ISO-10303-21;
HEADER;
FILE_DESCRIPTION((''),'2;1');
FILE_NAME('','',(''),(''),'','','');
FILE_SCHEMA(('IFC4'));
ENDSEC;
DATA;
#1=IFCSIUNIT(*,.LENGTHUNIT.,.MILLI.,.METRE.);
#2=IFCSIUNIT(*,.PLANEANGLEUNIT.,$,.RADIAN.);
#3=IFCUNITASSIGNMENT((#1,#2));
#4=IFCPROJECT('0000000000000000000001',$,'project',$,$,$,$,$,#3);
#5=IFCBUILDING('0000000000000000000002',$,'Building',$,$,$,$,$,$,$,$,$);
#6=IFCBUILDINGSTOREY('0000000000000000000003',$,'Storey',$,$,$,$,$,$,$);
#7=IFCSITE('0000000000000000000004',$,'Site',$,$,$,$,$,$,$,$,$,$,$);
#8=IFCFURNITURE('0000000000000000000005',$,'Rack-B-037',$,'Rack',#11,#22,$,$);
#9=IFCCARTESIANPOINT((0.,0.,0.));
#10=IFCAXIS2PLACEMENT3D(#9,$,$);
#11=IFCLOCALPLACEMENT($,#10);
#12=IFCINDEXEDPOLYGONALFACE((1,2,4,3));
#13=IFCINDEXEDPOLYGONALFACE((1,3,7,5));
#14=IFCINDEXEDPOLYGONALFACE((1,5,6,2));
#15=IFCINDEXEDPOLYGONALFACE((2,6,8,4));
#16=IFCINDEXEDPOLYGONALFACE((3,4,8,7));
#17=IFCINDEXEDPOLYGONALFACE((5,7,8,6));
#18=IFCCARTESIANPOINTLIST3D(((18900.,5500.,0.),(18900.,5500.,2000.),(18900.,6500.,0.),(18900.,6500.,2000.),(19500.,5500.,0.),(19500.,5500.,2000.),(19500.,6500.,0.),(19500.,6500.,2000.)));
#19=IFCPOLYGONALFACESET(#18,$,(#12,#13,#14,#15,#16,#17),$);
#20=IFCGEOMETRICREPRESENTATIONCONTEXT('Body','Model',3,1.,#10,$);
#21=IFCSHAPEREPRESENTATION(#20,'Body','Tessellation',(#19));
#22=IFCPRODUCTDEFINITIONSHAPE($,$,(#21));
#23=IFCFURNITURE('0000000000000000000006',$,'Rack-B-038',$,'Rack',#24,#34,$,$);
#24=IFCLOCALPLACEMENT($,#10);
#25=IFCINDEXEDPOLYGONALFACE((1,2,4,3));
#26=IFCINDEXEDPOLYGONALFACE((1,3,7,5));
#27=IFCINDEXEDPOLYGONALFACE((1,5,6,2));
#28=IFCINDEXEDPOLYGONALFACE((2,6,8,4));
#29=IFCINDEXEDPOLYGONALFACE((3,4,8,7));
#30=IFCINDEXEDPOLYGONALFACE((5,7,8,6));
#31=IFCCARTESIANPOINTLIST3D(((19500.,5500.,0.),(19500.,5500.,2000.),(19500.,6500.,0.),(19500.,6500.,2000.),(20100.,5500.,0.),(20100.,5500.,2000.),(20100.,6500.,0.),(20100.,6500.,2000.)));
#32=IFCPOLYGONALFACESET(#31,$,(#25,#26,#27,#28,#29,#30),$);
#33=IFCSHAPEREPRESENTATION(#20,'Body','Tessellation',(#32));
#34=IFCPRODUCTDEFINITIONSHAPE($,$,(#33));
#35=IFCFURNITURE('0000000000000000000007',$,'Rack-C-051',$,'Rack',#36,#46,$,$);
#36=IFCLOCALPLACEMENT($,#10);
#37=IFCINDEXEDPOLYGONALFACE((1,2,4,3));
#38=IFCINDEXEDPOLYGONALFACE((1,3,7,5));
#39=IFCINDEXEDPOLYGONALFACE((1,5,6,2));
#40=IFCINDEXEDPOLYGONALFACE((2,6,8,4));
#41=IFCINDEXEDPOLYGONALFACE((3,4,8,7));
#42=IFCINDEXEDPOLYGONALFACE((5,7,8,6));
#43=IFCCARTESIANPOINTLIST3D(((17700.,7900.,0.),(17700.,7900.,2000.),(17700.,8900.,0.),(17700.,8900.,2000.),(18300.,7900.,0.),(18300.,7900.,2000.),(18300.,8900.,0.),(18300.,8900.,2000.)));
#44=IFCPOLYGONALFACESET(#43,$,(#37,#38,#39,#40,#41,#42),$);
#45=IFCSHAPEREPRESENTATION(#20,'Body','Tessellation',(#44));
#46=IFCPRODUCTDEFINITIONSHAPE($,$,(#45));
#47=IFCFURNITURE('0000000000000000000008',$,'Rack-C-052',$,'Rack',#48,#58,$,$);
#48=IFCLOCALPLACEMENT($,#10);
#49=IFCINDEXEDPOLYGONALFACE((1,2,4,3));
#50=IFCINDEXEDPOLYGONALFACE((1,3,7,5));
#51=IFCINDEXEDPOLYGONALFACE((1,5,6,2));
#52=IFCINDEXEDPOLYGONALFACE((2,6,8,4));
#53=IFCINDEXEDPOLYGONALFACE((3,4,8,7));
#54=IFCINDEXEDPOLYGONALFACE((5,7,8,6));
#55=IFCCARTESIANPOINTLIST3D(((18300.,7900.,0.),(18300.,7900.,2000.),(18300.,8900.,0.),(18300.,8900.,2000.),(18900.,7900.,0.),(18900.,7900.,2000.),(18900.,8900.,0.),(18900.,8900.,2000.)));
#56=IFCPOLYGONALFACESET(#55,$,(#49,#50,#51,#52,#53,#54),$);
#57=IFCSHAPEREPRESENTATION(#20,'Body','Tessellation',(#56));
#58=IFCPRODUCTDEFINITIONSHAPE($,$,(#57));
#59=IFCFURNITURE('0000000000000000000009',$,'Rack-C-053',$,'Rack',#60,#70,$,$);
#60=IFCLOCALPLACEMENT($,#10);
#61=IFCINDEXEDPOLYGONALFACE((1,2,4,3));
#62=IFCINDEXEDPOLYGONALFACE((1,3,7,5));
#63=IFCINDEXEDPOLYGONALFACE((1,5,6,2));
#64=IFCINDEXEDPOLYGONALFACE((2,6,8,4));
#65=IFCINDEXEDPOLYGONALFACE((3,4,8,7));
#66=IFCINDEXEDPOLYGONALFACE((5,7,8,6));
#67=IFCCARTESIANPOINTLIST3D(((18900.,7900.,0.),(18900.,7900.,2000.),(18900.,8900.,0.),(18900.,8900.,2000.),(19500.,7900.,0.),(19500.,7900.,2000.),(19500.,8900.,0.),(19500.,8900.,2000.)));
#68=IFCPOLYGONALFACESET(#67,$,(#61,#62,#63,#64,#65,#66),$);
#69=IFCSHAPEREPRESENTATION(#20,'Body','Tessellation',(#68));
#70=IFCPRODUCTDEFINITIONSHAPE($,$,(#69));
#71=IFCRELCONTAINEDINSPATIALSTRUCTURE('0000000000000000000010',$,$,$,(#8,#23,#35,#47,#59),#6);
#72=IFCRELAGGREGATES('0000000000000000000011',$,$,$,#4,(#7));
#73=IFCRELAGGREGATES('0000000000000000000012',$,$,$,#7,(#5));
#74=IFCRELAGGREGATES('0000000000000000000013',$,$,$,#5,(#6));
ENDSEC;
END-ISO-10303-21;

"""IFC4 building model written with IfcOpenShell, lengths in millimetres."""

from ifc_helpers import new_model, si_unit, frame, origin, place, context, project, spatial, rectangle, extrude, element, save


model = new_model("IFC4")

# Units and contexts
model_context = context("Model", 3, precision=1.0, world=origin(), identifier="Body")
ifc_project = project(units=[si_unit("LENGTHUNIT", "METRE", prefix="MILLI"), si_unit("PLANEANGLEUNIT", "RADIAN")])

# Site, building, storey
site = spatial("IfcSite", under=ifc_project, Name="Site")
building = spatial("IfcBuilding", under=site, Name="Building")
storey = spatial("IfcBuildingStorey", under=building, Name="Storey")

# Furniture
for number, where, z_axis, x_axis, name in (
    (1, (19200.0, 6000.0, 0.0), (0.0, 0.0, 1.0), (1.0, 0.0, 0.0), "Rack-B-037"),
    (2, (19800.0, 6000.0, 0.0), (0.0, 0.0, 1.0), (1.0, 0.0, 0.0), "Rack-B-038"),
    (3, (18000.0, 8400.0, 0.0), (0.0, 0.0, 1.0), (1.0, 0.0, 0.0), "Rack-C-051"),
    (4, (18600.0, 8400.0, 0.0), (0.0, 0.0, 1.0), (1.0, 0.0, 0.0), "Rack-C-052"),
    (5, (19200.0, 8400.0, 0.0), (0.0, 0.0, 1.0), (1.0, 0.0, 0.0), "Rack-C-053"),
):
    element("IfcFurniture", number, at=place(None, frame(where, z_axis=z_axis, x_axis=x_axis)), inside=storey, Name=name, ObjectType="Rack", context=model_context, shape_type="SweptSolid", body=[
        extrude(rectangle(XDim=600.0, YDim=1000.0), origin(), (0.0, 0.0, 1.0), 2000.0),
    ])

save(model, "model.ifc")
